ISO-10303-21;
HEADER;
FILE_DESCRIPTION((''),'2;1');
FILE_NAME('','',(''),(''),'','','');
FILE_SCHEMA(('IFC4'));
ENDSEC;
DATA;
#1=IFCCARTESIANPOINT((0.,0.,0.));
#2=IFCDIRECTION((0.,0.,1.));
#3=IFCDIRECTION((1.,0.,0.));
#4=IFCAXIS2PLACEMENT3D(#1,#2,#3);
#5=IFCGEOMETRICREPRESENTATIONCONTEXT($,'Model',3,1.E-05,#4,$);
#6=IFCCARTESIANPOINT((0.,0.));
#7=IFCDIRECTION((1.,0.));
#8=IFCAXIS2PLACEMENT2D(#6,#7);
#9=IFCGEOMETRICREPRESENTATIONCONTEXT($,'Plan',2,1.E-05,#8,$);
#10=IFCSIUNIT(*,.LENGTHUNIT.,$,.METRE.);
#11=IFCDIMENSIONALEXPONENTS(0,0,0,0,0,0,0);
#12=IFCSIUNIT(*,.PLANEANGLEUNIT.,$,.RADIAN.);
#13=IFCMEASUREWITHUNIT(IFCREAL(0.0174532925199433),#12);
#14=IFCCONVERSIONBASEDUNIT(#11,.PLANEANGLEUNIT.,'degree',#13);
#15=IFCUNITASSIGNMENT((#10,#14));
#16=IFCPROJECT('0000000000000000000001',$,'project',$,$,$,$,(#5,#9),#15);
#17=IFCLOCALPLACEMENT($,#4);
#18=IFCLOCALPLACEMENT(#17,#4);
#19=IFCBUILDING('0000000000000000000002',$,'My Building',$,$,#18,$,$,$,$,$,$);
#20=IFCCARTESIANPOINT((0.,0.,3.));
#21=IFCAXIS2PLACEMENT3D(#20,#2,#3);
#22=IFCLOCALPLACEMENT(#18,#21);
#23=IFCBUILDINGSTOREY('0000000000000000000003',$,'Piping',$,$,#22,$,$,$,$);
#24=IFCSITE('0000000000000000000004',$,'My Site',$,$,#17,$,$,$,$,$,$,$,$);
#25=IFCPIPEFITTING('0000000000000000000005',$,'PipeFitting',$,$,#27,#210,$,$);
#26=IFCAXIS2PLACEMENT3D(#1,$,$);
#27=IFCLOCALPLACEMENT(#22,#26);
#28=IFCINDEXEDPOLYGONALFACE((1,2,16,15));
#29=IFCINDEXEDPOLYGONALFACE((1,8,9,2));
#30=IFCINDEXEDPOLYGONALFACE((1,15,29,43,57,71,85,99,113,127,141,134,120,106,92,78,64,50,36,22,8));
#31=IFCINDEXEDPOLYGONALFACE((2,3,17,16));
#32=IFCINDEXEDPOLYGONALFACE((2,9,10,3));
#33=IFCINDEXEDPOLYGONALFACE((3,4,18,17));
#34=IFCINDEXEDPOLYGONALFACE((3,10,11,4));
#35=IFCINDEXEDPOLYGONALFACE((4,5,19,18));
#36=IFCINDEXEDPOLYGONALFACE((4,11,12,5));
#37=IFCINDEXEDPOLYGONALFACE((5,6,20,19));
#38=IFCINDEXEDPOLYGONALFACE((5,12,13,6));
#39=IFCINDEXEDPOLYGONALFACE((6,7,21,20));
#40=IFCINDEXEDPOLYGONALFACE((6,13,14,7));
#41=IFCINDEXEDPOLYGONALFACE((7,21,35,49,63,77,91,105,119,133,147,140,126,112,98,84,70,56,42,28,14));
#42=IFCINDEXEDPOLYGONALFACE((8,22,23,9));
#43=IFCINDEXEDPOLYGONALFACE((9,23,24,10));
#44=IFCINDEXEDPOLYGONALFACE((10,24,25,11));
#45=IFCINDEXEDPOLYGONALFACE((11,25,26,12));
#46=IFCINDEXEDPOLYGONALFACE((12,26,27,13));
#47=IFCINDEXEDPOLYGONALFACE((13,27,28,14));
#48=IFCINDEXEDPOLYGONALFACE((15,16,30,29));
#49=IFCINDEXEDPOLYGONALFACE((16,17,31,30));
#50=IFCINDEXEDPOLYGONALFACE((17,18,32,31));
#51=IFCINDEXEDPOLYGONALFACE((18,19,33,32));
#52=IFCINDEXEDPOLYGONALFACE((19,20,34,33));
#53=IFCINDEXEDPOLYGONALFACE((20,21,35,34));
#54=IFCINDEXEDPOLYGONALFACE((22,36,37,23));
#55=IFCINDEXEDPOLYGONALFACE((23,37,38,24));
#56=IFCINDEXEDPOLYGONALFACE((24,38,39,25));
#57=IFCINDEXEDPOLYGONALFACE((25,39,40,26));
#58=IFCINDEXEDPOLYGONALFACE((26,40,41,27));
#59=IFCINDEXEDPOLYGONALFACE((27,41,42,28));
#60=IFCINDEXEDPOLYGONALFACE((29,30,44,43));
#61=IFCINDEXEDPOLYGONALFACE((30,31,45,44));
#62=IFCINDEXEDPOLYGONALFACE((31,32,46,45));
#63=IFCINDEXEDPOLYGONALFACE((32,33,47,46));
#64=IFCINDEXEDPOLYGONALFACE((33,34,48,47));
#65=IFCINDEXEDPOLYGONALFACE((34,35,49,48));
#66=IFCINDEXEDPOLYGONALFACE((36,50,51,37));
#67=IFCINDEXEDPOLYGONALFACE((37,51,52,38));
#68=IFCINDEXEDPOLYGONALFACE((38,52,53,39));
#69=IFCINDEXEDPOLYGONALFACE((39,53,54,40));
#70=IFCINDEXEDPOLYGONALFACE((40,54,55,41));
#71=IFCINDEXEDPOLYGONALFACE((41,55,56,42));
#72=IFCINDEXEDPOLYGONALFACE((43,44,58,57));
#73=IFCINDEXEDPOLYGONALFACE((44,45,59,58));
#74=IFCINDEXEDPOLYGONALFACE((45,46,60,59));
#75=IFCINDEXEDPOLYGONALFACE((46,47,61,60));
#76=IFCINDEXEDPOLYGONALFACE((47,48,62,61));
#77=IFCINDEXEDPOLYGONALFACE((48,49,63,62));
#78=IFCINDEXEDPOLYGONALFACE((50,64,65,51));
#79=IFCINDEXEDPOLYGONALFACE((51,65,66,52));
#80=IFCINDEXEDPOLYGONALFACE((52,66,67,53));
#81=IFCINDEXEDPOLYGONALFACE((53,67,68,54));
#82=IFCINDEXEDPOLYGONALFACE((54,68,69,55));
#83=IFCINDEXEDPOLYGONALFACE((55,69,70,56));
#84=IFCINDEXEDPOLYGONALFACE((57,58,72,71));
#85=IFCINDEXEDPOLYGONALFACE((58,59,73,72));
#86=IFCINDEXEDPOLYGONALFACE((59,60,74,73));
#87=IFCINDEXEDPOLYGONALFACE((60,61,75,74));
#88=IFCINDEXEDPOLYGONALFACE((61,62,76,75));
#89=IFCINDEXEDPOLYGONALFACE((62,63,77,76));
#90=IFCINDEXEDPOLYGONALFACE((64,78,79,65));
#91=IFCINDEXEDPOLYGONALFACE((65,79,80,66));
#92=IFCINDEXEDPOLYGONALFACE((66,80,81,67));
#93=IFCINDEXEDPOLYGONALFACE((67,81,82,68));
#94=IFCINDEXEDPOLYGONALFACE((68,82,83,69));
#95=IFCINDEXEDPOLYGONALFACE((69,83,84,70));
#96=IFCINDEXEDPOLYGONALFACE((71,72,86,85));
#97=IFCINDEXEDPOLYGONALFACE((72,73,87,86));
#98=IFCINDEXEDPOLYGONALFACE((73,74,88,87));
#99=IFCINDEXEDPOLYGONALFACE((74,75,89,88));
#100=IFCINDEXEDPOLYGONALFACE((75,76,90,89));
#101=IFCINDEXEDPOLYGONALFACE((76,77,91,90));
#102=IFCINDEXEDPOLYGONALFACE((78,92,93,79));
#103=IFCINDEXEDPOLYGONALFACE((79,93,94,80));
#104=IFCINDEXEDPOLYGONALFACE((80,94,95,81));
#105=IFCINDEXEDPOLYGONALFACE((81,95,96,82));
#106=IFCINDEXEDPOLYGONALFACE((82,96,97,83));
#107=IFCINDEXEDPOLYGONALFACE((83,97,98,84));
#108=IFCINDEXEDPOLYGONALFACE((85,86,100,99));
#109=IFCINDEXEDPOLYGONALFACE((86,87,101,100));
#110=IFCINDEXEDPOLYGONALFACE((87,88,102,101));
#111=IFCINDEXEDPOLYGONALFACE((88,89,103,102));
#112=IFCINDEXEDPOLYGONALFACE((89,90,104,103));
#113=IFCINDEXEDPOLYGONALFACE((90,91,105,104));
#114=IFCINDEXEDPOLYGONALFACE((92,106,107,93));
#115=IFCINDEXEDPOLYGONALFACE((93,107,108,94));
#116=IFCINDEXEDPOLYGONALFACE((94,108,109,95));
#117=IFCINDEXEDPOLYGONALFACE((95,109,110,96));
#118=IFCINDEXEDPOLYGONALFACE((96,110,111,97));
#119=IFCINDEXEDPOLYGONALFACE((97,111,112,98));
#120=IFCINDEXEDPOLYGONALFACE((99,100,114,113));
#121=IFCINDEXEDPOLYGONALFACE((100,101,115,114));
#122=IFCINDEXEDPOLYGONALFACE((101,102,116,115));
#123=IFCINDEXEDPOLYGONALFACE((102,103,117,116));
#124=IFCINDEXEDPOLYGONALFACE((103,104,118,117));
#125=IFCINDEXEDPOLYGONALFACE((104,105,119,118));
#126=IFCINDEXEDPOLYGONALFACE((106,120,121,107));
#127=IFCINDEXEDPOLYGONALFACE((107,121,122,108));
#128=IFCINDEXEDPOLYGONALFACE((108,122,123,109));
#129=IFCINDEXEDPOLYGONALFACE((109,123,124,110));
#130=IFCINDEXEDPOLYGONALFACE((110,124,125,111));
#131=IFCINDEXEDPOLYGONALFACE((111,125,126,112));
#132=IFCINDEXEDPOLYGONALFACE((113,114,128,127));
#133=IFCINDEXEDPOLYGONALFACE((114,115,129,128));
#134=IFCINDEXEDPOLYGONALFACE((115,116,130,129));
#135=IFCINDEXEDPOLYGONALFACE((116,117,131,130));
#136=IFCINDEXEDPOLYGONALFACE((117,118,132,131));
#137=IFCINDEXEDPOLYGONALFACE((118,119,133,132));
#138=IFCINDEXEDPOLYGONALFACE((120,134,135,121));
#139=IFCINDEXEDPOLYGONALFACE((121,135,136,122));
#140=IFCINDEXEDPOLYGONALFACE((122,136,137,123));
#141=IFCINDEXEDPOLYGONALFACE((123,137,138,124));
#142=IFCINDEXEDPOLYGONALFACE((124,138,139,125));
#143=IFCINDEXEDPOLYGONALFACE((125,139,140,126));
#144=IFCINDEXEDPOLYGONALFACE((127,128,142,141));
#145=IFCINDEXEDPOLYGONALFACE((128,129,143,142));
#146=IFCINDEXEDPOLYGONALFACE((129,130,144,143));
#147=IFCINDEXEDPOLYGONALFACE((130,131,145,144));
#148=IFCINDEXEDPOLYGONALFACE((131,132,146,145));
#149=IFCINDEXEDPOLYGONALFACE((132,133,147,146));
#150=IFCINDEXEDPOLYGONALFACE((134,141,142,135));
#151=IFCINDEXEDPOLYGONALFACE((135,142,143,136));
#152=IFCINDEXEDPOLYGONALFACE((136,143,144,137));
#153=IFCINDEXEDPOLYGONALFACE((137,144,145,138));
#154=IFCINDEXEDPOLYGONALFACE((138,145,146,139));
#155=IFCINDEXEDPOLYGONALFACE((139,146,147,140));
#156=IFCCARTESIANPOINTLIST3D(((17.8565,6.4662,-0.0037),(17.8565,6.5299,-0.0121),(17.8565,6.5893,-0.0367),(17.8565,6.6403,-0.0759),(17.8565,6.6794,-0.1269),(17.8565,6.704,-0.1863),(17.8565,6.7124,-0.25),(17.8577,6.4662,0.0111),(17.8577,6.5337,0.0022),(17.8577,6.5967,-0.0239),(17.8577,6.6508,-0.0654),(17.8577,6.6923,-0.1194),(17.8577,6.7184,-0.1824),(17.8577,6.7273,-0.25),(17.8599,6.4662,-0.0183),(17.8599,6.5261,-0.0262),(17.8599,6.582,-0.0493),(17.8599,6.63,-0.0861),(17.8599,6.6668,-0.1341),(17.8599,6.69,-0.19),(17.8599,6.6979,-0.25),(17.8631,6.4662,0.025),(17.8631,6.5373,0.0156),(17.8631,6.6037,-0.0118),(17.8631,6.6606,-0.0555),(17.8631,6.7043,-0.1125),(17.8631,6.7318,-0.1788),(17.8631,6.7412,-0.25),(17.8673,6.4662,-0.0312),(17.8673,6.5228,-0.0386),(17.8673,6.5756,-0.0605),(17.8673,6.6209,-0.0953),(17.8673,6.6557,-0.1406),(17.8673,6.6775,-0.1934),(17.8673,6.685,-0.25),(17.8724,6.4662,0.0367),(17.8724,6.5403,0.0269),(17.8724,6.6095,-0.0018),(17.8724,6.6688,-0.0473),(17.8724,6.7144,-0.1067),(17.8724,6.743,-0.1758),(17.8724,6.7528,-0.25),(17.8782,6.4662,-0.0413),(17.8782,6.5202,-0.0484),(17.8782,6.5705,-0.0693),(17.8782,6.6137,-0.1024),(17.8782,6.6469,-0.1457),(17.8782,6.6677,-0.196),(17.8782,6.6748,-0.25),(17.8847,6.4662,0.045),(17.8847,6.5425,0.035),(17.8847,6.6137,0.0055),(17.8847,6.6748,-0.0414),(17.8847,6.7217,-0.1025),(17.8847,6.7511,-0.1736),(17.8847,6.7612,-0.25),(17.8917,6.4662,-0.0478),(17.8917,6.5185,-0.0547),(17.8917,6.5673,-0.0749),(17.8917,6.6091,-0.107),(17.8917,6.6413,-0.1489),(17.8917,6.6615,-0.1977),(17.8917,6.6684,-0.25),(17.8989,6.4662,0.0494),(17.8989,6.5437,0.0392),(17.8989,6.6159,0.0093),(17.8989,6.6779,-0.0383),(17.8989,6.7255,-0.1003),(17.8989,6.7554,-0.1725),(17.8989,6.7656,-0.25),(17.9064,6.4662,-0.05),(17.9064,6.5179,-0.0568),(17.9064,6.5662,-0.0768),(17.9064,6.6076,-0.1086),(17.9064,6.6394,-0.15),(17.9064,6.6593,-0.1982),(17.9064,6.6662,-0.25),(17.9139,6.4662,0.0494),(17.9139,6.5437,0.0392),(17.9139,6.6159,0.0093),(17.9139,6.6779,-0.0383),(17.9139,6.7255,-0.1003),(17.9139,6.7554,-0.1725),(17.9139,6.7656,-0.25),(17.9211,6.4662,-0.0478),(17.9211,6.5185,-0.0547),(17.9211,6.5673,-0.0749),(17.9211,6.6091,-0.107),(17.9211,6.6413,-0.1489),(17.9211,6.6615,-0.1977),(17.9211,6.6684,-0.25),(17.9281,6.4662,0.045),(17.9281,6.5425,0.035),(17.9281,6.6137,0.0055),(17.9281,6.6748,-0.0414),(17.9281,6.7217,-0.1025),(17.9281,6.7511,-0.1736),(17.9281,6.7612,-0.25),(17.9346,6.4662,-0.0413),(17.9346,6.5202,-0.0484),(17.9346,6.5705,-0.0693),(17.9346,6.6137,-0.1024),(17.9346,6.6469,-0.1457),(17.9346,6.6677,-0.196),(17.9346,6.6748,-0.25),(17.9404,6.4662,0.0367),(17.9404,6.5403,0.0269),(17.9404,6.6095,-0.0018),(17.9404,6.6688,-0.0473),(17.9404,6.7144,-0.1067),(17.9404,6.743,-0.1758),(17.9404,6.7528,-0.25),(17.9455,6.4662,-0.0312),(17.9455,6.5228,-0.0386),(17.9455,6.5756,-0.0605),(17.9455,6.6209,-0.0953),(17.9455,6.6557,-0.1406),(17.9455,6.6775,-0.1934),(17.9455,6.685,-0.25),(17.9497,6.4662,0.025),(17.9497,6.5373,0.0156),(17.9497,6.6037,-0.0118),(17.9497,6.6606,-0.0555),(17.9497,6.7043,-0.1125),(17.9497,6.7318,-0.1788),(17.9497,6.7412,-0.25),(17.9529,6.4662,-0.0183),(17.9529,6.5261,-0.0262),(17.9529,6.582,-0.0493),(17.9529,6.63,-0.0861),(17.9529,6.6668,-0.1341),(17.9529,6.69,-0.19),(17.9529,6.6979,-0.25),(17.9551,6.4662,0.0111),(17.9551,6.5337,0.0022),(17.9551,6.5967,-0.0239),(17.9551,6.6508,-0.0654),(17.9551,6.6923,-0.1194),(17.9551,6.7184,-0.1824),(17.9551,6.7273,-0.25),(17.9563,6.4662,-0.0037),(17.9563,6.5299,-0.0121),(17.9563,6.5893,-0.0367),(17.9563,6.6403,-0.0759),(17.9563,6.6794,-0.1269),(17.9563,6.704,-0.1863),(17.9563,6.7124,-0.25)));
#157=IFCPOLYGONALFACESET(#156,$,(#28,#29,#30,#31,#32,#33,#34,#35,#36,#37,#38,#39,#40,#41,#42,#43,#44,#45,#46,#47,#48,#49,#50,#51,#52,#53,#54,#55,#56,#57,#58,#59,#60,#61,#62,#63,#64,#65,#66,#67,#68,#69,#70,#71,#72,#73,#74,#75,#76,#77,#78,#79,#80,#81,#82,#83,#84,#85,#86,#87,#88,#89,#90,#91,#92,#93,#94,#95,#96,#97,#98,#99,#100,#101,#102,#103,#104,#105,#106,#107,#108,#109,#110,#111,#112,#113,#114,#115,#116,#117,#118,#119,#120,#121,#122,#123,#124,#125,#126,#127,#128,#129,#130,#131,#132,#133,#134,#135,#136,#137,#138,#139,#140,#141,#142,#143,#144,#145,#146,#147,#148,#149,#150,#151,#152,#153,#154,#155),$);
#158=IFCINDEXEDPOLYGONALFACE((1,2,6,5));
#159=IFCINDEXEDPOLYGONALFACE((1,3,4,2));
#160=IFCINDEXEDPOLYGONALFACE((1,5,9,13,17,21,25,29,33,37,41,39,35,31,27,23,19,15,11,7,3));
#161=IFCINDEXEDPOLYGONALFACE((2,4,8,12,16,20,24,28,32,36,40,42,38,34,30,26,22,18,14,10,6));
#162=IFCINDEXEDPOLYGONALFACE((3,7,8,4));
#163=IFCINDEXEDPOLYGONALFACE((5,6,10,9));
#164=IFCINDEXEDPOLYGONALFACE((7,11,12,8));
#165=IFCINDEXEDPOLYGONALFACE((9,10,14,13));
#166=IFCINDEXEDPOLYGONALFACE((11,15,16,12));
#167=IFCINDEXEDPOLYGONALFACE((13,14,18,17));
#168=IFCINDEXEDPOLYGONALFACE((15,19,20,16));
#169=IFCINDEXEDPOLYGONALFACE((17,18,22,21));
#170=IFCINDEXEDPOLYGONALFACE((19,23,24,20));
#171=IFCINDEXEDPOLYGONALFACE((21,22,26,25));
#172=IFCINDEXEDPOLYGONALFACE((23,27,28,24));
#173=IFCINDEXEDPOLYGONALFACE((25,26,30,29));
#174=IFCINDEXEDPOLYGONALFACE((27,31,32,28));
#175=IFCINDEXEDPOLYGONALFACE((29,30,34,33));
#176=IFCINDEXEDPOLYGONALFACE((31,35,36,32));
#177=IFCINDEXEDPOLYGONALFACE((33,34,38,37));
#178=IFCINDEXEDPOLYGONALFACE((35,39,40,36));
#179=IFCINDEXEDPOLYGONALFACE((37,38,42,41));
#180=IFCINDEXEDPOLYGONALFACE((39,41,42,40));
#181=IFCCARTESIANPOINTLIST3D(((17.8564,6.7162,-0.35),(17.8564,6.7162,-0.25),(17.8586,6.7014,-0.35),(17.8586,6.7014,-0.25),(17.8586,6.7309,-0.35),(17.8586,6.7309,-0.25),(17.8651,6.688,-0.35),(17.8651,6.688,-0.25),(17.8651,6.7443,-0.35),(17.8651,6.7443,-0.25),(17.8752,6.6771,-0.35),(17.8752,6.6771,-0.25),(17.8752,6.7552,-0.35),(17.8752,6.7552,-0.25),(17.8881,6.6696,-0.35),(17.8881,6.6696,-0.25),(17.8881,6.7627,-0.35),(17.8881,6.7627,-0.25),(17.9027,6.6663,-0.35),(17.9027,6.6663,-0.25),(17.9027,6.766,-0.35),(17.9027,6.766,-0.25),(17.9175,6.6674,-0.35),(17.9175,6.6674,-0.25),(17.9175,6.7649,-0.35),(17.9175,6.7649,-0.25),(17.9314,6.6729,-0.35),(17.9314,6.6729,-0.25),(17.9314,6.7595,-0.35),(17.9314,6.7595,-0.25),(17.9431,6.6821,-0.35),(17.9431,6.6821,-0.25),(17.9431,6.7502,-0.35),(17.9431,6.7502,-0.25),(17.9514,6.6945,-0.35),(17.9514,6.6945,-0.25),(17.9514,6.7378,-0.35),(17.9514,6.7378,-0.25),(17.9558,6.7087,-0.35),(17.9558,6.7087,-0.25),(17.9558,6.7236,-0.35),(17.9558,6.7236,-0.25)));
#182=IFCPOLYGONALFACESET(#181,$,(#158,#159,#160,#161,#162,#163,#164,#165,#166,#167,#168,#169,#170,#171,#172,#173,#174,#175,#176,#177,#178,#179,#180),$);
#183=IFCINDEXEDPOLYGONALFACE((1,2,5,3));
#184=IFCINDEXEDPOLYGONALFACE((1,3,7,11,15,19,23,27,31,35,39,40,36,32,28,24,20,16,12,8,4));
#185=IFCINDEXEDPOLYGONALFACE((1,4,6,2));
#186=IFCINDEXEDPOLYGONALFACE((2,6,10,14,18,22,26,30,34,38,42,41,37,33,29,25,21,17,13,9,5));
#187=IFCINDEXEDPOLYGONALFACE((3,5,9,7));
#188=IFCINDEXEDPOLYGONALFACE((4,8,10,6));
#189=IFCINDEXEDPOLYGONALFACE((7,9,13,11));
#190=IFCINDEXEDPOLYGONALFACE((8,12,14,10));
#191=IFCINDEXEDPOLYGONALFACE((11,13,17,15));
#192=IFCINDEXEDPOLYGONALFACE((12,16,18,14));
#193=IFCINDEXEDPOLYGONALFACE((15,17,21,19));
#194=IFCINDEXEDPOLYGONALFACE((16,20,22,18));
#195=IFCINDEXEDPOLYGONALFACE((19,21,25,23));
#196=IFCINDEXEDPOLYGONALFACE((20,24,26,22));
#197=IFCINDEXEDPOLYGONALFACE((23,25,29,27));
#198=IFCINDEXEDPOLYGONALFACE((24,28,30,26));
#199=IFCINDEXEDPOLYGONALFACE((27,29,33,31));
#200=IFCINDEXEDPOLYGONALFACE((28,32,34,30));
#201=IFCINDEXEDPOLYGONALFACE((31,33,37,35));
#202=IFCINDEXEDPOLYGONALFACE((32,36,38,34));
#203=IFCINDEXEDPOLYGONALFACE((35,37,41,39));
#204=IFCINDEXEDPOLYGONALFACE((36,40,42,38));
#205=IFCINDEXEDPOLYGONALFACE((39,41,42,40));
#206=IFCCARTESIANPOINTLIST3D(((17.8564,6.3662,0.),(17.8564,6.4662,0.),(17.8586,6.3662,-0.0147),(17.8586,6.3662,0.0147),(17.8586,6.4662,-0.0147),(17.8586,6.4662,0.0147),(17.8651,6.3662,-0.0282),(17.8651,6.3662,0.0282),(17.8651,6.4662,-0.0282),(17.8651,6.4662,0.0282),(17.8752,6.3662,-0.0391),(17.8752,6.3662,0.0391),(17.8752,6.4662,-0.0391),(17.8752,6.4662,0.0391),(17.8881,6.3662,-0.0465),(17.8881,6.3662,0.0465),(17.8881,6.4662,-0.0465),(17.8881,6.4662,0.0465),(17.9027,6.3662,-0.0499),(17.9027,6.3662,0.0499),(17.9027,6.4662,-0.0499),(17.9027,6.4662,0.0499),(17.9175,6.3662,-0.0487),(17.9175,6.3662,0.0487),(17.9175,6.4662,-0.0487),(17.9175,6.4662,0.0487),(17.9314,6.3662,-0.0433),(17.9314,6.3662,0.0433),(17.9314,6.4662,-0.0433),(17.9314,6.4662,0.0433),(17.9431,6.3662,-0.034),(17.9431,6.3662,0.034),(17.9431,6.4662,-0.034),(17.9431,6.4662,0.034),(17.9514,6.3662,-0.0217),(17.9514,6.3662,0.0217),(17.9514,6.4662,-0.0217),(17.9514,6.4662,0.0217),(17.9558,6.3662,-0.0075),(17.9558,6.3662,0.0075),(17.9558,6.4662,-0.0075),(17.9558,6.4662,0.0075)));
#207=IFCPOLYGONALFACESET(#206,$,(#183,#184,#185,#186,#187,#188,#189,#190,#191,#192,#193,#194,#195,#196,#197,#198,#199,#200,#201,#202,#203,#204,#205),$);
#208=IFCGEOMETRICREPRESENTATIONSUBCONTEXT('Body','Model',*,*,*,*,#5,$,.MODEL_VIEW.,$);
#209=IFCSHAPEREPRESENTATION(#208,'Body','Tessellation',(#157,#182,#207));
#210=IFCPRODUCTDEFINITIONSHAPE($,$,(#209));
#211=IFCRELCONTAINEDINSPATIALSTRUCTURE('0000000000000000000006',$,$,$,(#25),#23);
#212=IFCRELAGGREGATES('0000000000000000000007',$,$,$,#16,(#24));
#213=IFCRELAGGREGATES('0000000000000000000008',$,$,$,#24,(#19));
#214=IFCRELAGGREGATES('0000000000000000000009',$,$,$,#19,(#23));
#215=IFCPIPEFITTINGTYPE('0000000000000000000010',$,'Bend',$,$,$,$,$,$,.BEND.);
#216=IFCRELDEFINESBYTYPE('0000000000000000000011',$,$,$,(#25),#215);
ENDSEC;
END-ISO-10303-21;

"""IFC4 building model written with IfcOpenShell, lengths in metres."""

from ifc_helpers import new_model, entity, si_unit, converted_unit, frame, origin_with_axes, origin_2d_with_axis, place, context, subcontext, project, spatial, circle, extrude, source, transform, mapped, type_object, type_shapes, element, save


model = new_model("IFC4")

# Units and contexts
model_context = context("Model", 3, precision=1e-05, world=origin_with_axes())
plan_context = context("Plan", 2, precision=1e-05, world=origin_2d_with_axis())
body_context = subcontext(model_context, "Body", "Model", "MODEL_VIEW")
ifc_project = project(units=[si_unit("LENGTHUNIT", "METRE"), converted_unit("PLANEANGLEUNIT", "degree", entity("IfcReal", 0.0174532925199433), si_unit("PLANEANGLEUNIT", "RADIAN"), dimensions=[0, 0, 0, 0, 0, 0, 0])], contexts=[model_context, plan_context])

# Site, building, storey
site_placement = place(None, origin_with_axes())
site = spatial("IfcSite", under=ifc_project, at=site_placement, Name="My Site")
building_placement = place(site_placement, origin_with_axes())
building = spatial("IfcBuilding", under=site, at=building_placement, Name="My Building")
storey_placement = place(building_placement, frame((0.0, 0.0, 3.0), z_axis=(0.0, 0.0, 1.0), x_axis=(1.0, 0.0, 0.0)))
storey = spatial("IfcBuildingStorey", under=building, at=storey_placement, Name="Piping")

# Pipe fitting
pipe_fitting_type = type_object("IfcPipeFittingType", Name="Bend", PredefinedType="BEND")
shared_shape = source(origin_with_axes(), body_context, "Body", "SolidModel", [
    entity("IfcSweptDiskSolid", entity("IfcIndexedPolyCurve", entity("IfcCartesianPointList3D", [[0.0, 0.0, -0.1], [0.0, -0.0732, -0.2768], [0.0, -0.25, -0.35]]), [entity("IfcArcIndex", [1, 2, 3])]), 0.05),
    extrude(circle(Radius=0.05), origin_with_axes(), (0.0, 0.0, -1.0), 0.1),
    extrude(circle(Radius=0.05), frame((0.0, -0.25, -0.35), z_axis=(0.0, -1.0, 0.0), x_axis=(1.0, 0.0, 0.0)), (0.0, 0.0, 1.0), 0.1),
])
type_shapes(pipe_fitting_type, [shared_shape])
for number, where, z_axis, x_axis, name in (
    (1, (17.9064, 6.7162, -0.35), (0.0, 0.0, -1.0), (-1.0, 0.0, 0.0), "PipeFitting"),
):
    element("IfcPipeFitting", number, at=place(storey_placement, frame(where, z_axis=z_axis, x_axis=x_axis)), inside=storey, type_object=pipe_fitting_type, Name=name, context=body_context, shape_type="MappedRepresentation", body=[
        mapped(shared_shape, transform((0.0, 0.0, 0.0), x_axis=(1.0, 0.0, 0.0), y_axis=(0.0, 1.0, 0.0), z_axis=(0.0, 0.0, 1.0), scale=1.0)),
    ])

save(model, "model.ifc")
